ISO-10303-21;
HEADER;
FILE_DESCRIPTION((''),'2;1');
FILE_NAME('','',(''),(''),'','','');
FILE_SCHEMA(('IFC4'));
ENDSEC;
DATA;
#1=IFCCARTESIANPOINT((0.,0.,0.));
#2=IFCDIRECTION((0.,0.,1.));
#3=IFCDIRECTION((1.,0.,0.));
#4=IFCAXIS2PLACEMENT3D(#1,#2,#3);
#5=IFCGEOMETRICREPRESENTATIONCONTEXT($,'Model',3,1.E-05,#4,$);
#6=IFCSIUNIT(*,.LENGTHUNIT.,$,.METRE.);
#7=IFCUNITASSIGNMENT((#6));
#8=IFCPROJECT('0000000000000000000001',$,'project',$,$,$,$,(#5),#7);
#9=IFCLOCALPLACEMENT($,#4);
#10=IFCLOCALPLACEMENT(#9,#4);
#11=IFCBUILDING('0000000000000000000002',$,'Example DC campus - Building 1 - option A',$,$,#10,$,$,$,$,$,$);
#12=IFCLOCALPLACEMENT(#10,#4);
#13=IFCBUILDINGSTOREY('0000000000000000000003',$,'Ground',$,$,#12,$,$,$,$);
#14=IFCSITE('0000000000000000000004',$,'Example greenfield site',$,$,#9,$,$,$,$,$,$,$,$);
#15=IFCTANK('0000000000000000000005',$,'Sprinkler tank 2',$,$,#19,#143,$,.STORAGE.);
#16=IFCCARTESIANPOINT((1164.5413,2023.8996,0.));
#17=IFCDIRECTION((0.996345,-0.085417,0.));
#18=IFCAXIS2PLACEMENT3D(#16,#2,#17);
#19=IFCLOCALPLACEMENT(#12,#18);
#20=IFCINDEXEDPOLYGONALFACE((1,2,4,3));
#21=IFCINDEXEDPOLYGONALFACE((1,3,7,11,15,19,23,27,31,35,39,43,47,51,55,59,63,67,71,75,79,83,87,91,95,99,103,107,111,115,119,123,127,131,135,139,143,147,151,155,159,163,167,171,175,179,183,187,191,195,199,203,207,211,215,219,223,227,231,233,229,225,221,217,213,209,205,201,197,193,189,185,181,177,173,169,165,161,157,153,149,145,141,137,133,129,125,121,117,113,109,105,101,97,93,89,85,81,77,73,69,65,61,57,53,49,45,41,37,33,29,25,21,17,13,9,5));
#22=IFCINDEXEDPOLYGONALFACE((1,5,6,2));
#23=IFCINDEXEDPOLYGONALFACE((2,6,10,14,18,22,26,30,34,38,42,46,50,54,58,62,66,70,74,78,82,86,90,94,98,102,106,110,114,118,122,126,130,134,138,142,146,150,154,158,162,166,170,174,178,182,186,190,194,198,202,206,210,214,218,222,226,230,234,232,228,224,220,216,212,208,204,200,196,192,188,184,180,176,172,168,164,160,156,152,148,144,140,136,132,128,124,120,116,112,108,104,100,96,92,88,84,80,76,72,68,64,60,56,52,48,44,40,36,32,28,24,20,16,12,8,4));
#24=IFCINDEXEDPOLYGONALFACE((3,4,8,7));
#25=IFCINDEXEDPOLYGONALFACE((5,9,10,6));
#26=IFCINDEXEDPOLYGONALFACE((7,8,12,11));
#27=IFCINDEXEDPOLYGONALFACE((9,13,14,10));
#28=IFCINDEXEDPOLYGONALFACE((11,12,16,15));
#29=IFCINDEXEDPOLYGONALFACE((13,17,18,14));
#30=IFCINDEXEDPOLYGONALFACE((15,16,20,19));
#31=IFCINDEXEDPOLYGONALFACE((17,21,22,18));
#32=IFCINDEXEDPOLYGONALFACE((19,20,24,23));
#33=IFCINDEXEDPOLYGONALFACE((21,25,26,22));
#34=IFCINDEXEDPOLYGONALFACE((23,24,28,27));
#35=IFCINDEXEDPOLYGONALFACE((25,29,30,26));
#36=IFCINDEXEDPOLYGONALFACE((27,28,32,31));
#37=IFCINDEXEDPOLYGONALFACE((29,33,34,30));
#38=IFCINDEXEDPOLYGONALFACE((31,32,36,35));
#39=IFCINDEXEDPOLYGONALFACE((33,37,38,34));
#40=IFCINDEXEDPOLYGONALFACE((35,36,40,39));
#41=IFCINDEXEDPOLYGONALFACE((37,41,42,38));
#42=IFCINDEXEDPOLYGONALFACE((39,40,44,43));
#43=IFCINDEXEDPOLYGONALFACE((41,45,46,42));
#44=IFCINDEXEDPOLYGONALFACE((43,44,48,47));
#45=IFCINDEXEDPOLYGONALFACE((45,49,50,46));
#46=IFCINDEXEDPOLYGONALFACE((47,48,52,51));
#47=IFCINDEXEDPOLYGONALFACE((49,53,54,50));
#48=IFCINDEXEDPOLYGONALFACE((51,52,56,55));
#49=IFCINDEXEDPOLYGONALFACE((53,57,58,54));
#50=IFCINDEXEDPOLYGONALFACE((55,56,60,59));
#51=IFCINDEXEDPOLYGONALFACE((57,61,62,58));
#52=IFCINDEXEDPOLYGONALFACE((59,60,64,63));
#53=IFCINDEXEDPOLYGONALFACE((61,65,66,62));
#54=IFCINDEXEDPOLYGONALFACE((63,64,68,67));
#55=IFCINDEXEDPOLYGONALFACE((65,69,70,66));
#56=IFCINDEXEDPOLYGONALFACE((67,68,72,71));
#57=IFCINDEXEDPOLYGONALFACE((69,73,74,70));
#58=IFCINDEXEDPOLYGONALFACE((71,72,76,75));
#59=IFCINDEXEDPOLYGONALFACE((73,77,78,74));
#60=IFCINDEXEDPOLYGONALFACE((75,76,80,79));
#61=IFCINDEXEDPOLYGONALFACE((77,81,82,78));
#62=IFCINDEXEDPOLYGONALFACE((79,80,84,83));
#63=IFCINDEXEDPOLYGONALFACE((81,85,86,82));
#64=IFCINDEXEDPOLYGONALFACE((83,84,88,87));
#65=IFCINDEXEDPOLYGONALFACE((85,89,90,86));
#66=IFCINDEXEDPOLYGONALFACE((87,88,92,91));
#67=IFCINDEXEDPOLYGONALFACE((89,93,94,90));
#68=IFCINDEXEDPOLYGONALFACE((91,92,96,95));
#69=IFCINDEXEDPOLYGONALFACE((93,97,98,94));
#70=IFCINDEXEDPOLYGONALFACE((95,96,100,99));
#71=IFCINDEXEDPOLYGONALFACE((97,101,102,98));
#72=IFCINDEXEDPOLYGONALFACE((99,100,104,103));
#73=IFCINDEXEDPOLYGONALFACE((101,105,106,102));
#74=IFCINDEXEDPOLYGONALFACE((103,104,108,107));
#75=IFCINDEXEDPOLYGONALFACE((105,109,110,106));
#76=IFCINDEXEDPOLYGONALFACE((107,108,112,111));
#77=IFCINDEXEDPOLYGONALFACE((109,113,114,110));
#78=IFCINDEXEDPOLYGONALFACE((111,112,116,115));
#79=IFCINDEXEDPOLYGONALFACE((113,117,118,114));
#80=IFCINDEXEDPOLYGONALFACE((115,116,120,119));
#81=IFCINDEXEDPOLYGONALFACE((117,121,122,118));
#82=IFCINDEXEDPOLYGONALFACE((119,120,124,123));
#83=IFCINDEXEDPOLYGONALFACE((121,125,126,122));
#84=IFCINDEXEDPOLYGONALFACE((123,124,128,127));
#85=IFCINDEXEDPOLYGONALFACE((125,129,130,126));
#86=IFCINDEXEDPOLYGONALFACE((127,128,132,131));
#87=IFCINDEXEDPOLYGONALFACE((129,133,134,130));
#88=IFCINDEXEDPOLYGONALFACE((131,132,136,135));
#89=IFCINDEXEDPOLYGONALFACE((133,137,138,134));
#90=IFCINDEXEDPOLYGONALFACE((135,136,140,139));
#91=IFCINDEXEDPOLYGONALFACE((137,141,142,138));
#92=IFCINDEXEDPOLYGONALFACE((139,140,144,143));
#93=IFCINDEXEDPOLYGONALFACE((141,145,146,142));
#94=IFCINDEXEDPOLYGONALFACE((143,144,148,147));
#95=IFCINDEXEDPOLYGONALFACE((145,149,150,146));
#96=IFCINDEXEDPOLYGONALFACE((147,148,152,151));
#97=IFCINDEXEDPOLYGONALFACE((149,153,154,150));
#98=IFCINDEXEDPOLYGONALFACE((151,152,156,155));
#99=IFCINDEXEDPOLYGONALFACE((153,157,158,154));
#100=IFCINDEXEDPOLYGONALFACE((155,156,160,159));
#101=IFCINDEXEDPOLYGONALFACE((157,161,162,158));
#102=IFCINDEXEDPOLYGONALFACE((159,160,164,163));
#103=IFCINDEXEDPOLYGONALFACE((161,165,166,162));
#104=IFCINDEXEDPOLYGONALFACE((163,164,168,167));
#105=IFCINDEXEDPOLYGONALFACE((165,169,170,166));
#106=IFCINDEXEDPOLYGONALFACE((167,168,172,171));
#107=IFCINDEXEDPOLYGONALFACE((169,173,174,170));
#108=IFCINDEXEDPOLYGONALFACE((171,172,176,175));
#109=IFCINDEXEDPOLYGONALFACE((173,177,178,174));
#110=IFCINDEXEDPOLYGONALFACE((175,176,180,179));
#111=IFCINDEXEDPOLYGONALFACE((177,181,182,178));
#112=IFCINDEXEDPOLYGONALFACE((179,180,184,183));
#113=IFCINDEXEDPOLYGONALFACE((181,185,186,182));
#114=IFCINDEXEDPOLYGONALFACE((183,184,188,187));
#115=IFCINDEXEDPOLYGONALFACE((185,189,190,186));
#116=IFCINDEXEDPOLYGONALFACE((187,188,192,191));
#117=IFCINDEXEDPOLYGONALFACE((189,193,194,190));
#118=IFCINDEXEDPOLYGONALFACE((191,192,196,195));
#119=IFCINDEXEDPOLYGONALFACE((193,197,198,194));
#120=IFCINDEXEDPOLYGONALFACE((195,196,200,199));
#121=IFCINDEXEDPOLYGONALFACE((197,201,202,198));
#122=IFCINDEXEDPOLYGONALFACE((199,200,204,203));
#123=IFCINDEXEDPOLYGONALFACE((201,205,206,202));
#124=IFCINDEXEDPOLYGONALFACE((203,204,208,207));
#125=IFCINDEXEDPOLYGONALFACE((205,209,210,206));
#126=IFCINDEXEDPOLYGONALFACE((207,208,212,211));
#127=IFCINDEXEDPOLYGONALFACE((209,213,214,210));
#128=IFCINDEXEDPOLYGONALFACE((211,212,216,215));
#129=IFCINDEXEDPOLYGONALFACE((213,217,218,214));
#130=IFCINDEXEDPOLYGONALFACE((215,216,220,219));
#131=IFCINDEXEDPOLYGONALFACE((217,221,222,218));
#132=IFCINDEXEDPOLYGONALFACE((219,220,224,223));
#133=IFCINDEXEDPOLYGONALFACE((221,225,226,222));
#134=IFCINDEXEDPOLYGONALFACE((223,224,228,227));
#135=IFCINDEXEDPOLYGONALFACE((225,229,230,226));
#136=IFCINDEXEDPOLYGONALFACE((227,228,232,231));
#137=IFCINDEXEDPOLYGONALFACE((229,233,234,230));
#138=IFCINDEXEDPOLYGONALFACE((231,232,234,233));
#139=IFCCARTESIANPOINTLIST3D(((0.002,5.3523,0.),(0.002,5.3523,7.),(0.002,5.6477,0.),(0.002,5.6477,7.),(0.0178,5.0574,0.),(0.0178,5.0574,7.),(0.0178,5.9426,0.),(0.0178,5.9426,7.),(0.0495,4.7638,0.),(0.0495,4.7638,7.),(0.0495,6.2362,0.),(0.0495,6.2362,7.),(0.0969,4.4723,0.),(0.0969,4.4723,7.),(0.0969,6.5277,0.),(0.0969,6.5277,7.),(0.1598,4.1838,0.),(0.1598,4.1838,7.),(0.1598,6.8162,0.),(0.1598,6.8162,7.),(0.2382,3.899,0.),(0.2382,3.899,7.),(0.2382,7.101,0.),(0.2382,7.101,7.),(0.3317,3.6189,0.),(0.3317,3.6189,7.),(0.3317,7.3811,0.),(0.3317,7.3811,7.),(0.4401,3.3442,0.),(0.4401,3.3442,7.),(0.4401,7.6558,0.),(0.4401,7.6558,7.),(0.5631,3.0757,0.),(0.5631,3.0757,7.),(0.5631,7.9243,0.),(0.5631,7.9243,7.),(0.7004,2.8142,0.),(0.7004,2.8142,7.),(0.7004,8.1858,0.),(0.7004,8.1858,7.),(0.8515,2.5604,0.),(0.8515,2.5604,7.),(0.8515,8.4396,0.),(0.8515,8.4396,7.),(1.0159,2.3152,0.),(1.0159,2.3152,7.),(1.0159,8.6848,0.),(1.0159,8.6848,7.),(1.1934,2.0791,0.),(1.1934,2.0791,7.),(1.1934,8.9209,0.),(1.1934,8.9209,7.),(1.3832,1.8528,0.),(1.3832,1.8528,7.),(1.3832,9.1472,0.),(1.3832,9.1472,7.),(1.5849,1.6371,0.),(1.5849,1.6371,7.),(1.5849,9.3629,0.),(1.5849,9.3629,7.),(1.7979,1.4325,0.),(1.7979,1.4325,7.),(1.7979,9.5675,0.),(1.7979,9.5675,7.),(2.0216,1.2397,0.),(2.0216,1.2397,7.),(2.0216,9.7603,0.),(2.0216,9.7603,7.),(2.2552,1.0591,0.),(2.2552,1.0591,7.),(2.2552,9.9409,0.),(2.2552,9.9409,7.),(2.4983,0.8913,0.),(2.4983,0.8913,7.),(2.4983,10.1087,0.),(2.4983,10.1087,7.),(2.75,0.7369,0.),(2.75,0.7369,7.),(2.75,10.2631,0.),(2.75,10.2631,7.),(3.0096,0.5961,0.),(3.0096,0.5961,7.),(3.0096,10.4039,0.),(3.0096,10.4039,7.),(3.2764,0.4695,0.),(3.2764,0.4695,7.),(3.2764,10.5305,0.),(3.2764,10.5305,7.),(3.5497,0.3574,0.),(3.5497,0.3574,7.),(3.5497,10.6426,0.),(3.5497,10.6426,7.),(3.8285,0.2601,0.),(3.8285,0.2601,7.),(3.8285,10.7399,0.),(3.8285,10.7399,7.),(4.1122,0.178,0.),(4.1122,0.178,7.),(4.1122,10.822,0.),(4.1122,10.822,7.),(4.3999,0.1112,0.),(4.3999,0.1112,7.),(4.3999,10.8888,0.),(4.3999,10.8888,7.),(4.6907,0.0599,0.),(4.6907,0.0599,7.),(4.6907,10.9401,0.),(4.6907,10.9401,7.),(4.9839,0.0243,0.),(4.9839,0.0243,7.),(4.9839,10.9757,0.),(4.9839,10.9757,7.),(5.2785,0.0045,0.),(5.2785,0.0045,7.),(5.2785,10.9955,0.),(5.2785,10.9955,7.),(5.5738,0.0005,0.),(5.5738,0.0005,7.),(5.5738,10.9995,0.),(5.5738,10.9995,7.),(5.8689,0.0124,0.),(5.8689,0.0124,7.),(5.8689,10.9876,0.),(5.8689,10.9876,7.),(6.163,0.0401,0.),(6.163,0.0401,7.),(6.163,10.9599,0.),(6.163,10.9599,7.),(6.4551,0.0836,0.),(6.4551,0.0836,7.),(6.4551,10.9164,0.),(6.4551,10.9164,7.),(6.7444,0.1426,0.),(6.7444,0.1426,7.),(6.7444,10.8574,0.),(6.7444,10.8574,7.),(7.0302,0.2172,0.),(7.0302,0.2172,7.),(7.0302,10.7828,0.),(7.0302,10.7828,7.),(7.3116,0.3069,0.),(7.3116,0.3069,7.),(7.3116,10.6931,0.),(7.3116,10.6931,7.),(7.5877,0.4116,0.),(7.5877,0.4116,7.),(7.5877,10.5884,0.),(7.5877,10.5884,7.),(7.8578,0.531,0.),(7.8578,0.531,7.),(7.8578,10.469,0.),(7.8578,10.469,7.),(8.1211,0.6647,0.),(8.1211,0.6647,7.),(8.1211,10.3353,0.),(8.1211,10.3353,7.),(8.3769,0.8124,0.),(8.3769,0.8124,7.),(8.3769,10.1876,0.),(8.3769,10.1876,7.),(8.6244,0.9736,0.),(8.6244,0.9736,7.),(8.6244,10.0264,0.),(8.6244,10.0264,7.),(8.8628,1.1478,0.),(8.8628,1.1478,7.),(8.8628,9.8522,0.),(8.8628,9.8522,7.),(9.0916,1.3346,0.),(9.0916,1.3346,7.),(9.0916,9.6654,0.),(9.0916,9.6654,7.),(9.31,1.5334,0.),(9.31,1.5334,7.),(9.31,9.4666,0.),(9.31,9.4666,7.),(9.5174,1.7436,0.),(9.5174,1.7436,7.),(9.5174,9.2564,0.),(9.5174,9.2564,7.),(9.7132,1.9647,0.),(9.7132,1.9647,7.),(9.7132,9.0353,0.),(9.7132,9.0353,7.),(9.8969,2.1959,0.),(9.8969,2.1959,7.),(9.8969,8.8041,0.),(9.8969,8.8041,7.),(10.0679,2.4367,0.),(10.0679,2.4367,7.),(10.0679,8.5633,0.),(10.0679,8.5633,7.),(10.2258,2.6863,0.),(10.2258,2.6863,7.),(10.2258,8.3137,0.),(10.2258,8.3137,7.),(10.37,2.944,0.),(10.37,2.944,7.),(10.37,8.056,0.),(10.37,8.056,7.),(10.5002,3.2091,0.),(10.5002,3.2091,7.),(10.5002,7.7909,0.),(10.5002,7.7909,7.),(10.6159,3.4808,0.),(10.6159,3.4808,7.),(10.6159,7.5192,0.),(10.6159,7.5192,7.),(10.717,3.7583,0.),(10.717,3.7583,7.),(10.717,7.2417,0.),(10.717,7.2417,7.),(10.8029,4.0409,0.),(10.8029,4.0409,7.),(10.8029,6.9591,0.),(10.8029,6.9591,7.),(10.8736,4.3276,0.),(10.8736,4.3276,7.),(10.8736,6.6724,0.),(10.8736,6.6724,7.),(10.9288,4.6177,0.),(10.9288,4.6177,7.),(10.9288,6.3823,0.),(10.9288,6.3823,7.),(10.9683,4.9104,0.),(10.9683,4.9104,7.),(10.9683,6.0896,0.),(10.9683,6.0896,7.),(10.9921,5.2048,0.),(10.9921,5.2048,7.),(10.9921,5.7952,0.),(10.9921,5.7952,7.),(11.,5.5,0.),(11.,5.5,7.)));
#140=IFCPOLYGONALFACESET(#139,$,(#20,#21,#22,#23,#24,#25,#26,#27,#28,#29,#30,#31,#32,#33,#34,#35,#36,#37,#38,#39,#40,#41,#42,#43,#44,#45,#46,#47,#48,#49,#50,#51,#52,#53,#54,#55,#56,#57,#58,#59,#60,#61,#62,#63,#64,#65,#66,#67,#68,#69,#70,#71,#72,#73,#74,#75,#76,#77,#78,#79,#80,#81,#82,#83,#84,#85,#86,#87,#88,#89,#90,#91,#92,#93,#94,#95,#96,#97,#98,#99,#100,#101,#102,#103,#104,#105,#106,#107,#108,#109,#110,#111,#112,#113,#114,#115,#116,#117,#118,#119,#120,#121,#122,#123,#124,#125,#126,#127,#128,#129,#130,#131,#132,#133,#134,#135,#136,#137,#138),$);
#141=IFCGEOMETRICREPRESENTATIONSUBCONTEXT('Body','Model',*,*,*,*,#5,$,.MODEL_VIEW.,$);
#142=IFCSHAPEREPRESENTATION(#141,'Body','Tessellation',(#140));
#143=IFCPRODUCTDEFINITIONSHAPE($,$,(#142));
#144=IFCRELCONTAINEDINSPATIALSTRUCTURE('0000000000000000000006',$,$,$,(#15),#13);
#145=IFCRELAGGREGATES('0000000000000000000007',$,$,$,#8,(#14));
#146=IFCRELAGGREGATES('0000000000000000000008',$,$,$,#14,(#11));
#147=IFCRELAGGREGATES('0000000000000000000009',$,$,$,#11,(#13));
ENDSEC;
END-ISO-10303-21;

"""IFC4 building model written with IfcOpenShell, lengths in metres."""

from ifc_helpers import new_model, si_unit, frame, frame_2d, origin_with_axes, place, context, subcontext, project, spatial, circle_curve, outline, extrude, element, save


model = new_model("IFC4")

# Units and contexts
model_context = context("Model", 3, precision=1e-05, world=origin_with_axes())
body_context = subcontext(model_context, "Body", "Model", "MODEL_VIEW")
ifc_project = project(units=[si_unit("LENGTHUNIT", "METRE")], contexts=[model_context])

# Site, building, storey
site_placement = place(None, origin_with_axes())
site = spatial("IfcSite", under=ifc_project, at=site_placement, Name="Example greenfield site")
building_placement = place(site_placement, origin_with_axes())
building = spatial("IfcBuilding", under=site, at=building_placement, Name="Example DC campus - Building 1 - option A")
storey_placement = place(building_placement, origin_with_axes())
storey = spatial("IfcBuildingStorey", under=building, at=storey_placement, Name="Ground")

# Tank
for number, where, z_axis, x_axis, name in (
    (1, (1164.5413, 2023.8996, 0.0), (0.0, 0.0, 1.0), (0.996345, -0.085417, 0.0), "Sprinkler tank 2"),
):
    element("IfcTank", number, at=place(storey_placement, frame(where, z_axis=z_axis, x_axis=x_axis)), inside=storey, Name=name, PredefinedType="STORAGE", context=body_context, shape_type="SweptSolid", body=[
        extrude(outline(circle_curve(frame_2d((5.5, 5.5)), 5.5)), origin_with_axes(), (0.0, 0.0, 1.0), 7.0),
    ])

save(model, "model.ifc")
